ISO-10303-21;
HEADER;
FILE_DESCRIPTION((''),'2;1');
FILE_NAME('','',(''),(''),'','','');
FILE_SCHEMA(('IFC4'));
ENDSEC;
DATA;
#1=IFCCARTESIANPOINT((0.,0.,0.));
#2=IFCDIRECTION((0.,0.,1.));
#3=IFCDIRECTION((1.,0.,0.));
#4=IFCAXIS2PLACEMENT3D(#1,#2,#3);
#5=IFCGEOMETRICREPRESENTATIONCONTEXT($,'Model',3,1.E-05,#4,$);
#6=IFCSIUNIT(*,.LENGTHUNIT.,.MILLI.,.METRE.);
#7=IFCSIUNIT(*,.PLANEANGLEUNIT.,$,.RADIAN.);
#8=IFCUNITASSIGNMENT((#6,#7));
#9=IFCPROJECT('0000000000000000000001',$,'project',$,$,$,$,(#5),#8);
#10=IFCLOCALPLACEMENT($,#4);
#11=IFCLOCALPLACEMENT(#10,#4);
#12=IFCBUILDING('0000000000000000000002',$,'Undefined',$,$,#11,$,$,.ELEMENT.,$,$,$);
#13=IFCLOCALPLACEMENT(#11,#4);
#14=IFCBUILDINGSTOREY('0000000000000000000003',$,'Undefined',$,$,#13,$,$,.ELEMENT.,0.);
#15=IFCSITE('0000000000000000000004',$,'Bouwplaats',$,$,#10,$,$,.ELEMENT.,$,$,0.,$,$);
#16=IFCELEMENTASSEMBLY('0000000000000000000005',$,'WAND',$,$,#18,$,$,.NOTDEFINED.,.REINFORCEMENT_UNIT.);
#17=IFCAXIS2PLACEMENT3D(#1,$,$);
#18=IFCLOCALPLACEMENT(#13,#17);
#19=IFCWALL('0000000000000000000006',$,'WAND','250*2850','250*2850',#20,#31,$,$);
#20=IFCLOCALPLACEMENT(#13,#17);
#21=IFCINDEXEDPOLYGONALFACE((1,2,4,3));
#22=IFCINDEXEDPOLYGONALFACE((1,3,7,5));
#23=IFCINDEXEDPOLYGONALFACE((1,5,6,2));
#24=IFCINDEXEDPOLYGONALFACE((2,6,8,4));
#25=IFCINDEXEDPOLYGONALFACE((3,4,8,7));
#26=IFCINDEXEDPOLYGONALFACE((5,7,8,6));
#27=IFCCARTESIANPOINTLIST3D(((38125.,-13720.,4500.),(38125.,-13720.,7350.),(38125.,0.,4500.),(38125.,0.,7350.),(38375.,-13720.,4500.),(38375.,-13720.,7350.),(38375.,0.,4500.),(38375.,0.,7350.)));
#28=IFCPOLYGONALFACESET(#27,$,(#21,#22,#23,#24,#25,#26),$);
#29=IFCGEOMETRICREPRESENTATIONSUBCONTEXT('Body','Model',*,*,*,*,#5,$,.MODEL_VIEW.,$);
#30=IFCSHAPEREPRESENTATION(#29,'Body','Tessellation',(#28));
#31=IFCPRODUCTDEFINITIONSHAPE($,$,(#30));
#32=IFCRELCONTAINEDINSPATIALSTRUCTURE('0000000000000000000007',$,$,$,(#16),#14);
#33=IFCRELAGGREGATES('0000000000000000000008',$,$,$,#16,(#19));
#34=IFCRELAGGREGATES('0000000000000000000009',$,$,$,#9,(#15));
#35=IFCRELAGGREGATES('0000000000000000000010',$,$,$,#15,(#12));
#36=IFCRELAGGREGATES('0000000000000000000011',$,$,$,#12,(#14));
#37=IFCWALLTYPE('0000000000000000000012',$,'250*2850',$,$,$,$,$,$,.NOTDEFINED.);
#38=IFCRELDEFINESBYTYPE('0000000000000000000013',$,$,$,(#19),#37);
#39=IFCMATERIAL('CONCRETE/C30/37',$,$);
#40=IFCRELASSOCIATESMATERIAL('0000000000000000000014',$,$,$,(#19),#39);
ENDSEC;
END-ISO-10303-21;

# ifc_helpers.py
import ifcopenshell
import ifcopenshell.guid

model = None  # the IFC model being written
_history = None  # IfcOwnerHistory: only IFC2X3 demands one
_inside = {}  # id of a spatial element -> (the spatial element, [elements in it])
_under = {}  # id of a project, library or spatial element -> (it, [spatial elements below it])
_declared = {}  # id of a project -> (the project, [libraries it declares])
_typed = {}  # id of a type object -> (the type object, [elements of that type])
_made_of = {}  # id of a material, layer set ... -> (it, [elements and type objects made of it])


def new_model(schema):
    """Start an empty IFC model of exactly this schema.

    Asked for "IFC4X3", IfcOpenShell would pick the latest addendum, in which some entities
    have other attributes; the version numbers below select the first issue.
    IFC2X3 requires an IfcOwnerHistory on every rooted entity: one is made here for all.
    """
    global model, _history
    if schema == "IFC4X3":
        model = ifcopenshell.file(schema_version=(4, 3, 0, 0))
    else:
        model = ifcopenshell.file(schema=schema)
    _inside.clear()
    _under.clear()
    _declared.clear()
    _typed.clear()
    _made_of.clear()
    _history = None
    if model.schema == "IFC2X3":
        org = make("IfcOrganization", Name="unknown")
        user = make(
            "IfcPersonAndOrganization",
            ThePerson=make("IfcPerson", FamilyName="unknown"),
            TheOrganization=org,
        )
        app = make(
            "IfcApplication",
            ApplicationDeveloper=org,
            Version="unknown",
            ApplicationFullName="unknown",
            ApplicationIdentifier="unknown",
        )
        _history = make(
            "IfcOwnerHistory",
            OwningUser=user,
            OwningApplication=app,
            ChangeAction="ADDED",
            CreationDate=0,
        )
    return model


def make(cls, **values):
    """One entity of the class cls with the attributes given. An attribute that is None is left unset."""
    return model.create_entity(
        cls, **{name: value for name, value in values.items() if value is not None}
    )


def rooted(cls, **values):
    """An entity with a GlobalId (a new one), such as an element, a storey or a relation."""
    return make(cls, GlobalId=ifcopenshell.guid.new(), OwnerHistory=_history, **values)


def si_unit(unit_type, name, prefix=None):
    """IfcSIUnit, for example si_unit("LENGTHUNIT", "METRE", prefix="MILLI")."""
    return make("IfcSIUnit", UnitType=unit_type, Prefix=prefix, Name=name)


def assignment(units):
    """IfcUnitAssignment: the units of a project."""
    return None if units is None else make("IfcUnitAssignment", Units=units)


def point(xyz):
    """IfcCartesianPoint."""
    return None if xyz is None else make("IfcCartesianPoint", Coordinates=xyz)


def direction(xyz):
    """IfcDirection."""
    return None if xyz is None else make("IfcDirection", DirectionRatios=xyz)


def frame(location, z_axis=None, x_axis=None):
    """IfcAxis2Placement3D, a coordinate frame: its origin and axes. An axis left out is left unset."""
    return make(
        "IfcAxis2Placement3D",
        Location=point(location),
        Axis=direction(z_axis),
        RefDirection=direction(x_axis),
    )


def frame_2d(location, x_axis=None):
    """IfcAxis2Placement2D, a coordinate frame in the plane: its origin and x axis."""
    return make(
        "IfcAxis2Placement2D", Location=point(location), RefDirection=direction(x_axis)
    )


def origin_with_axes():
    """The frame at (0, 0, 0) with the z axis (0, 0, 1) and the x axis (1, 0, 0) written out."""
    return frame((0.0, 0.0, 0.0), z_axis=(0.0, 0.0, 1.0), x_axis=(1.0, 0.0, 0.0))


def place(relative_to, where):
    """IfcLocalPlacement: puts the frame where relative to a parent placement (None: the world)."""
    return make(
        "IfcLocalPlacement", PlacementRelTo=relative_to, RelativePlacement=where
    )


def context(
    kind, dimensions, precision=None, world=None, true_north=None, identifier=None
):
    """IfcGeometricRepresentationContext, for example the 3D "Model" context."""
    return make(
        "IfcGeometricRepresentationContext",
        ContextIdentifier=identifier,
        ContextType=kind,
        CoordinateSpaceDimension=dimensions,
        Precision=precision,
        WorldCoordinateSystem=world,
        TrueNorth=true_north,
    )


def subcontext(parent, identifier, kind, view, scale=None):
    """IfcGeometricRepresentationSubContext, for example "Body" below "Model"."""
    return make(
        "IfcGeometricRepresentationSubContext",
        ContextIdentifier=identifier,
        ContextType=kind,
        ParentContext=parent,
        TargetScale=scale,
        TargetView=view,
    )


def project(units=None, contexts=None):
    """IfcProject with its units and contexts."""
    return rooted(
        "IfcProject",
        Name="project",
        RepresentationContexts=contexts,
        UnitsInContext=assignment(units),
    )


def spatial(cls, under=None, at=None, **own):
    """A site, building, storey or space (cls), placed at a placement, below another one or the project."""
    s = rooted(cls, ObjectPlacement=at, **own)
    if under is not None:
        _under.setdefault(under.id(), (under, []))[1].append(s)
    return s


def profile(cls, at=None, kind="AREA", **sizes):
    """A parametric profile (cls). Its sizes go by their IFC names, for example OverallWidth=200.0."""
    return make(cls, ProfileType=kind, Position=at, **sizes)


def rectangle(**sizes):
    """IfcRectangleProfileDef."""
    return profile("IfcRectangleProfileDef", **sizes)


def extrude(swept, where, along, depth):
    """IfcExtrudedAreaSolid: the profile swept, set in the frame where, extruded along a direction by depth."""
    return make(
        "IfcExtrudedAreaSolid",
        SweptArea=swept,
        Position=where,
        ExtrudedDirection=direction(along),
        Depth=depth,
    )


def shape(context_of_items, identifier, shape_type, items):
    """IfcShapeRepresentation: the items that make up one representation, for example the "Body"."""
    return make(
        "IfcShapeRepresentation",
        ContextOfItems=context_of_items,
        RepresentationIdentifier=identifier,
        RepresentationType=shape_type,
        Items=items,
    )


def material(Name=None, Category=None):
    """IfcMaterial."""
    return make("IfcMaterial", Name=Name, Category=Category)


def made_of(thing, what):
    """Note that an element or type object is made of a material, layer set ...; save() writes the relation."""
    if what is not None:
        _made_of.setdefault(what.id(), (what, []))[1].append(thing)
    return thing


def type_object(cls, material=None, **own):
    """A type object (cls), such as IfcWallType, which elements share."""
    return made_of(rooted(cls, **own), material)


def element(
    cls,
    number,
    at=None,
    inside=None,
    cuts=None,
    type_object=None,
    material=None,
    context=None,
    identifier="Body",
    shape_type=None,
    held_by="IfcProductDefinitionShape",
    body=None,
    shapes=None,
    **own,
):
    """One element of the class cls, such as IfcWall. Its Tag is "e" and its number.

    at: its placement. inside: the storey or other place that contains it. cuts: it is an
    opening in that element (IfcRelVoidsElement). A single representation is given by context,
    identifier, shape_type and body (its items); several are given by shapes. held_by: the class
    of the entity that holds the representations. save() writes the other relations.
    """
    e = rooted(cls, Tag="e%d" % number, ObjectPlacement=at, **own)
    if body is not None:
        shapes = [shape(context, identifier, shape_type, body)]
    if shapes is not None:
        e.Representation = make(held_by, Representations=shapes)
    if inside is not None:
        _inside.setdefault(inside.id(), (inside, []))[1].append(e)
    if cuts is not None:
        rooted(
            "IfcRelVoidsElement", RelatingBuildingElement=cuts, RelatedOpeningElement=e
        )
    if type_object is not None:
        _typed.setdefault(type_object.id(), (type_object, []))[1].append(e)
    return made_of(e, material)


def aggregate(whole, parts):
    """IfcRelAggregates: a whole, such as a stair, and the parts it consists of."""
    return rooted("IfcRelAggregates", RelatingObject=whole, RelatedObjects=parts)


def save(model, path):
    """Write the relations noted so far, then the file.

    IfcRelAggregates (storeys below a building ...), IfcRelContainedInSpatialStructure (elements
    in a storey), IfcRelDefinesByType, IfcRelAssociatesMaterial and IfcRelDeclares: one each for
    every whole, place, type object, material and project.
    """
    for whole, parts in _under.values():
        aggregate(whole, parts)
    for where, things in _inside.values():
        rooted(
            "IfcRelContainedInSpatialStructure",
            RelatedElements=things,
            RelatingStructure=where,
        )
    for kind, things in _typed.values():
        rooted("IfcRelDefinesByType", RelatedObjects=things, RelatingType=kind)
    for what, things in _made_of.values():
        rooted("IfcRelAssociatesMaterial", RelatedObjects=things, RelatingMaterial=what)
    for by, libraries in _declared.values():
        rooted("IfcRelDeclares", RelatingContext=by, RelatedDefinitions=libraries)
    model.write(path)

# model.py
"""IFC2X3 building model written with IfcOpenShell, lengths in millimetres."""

from ifc_helpers import new_model, si_unit, frame, frame_2d, origin_with_axes, place, context, subcontext, project, spatial, rectangle, extrude, material, type_object, element, aggregate, save


model = new_model("IFC2X3")

# Units and contexts
model_context = context("Model", 3, precision=1e-05, world=origin_with_axes())
body_context = subcontext(model_context, "Body", "Model", "MODEL_VIEW")
ifc_project = project(units=[si_unit("LENGTHUNIT", "METRE", prefix="MILLI"), si_unit("PLANEANGLEUNIT", "RADIAN")], contexts=[model_context])

# Site, building, storey
site_placement = place(None, origin_with_axes())
site = spatial("IfcSite", under=ifc_project, at=site_placement, Name="Bouwplaats", CompositionType="ELEMENT", RefElevation=0.0)
building_placement = place(site_placement, origin_with_axes())
building = spatial("IfcBuilding", under=site, at=building_placement, Name="Undefined", CompositionType="ELEMENT")
storey_placement = place(building_placement, origin_with_axes())
storey = spatial("IfcBuildingStorey", under=building, at=storey_placement, Name="Undefined", CompositionType="ELEMENT", Elevation=0.0)

# Shared definitions
ifc_material_1 = material(Name="CONCRETE/C30/37")

# Element assembly, wall
assembly_1_placement = place(storey_placement, origin_with_axes())
assembly_1 = element("IfcElementAssembly", 1, at=assembly_1_placement, inside=storey, Name="WAND", AssemblyPlace="NOTDEFINED", PredefinedType="REINFORCEMENT_UNIT")
wall_type_1 = type_object("IfcWallType", Name="250*2850", PredefinedType="NOTDEFINED")
wall_1_placement = place(assembly_1_placement, frame((38250.0, -13720.0, 4500.0), z_axis=(0.0, 0.0, 1.0), x_axis=(0.0, 1.0, 0.0)))
wall_1 = element("IfcWall", 2, at=wall_1_placement, type_object=wall_type_1, material=ifc_material_1, Name="WAND", Description="250*2850", ObjectType="250*2850", context=body_context, shape_type="SweptSolid", body=[
    extrude(rectangle(XDim=13720.0, YDim=250.0, at=frame_2d((0.0, 6860.0), x_axis=(0.0, -1.0))), frame((0.0, 0.0, 0.0), z_axis=(0.0, 0.0, 1.0), x_axis=(0.0, -1.0, 0.0)), (0.0, 0.0, 1.0), 2850.0),
])
aggregate(assembly_1, [wall_1])

save(model, "model.ifc")
